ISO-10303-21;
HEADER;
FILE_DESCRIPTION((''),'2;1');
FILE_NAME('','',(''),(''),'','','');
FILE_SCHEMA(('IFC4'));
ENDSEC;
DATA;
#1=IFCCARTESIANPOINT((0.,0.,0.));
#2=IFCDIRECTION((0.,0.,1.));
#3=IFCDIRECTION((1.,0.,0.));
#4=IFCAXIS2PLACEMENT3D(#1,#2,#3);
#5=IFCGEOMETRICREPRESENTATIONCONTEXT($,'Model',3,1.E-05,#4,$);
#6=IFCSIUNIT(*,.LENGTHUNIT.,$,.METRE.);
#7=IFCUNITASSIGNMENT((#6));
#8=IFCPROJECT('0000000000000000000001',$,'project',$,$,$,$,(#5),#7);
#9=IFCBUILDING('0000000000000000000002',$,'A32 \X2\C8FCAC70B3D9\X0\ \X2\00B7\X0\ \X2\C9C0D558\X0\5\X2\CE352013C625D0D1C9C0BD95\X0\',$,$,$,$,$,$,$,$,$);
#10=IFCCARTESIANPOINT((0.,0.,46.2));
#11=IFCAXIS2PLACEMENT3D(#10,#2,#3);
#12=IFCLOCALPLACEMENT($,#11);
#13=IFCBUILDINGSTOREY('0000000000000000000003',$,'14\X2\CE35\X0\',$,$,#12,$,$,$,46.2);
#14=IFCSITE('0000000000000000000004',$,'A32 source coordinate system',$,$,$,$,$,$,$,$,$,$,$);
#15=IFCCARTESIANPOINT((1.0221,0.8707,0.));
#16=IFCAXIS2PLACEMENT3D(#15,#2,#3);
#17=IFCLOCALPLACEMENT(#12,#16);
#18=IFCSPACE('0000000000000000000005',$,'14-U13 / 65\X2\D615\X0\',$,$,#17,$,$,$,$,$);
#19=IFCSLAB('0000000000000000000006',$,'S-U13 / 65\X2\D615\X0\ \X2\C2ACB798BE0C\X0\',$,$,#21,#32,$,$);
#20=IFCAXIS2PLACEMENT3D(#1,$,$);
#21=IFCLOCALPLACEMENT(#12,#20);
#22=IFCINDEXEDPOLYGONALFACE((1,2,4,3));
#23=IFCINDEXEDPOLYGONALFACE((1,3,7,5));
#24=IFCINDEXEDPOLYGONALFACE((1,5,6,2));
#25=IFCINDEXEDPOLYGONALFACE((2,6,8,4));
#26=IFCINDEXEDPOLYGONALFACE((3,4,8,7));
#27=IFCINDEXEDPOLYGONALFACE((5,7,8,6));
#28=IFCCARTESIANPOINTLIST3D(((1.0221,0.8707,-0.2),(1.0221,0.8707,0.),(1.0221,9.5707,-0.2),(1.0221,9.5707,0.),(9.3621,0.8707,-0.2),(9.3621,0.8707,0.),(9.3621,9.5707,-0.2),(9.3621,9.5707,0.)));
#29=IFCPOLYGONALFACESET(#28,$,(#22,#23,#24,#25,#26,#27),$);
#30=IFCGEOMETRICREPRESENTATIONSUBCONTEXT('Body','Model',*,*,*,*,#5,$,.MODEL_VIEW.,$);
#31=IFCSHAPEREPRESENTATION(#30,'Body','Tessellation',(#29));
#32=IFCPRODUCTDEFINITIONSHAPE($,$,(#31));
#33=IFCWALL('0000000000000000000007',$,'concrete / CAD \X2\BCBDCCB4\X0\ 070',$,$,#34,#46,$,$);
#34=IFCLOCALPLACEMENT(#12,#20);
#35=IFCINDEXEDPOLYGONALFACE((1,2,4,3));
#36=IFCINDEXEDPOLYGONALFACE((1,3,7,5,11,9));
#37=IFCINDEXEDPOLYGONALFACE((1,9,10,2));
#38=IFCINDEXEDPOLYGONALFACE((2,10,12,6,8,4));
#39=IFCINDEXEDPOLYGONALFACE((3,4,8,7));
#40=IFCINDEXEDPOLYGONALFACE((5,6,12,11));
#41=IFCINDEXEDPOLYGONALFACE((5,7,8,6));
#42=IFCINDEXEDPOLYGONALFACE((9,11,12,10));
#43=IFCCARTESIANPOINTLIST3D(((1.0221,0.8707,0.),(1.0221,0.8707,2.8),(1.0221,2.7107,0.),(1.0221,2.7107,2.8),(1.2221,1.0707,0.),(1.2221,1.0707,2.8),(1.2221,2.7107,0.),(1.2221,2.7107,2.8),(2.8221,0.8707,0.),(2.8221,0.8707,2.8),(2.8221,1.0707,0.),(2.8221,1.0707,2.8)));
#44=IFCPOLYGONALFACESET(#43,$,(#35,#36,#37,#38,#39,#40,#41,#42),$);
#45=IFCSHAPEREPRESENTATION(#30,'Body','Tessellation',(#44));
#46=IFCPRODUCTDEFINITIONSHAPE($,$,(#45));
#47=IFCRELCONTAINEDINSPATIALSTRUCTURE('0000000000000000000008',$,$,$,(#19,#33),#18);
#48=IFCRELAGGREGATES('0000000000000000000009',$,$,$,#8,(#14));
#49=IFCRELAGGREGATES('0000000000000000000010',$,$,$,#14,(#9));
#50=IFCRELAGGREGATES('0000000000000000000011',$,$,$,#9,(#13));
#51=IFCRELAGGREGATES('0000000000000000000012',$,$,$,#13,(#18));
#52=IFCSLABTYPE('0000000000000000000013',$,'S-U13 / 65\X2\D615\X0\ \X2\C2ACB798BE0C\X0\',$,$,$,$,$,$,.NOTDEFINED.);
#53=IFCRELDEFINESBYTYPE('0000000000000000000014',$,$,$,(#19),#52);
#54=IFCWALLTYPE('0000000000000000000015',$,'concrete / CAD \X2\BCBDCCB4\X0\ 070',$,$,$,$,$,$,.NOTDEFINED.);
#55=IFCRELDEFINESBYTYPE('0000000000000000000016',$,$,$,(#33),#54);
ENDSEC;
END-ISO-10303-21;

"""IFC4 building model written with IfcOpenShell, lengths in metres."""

from ifc_helpers import new_model, si_unit, frame, origin, origin_with_axes, place, context, subcontext, project, spatial, polyline, outline, extrude, source, transform, mapped, type_object, type_shapes, element, save


model = new_model("IFC4")

# Units and contexts
model_context = context("Model", 3, precision=1e-05, world=origin_with_axes())
body_context = subcontext(model_context, "Body", "Model", "MODEL_VIEW")
ifc_project = project(units=[si_unit("LENGTHUNIT", "METRE")], contexts=[model_context])

# Site, building, storey, space
storey_placement = place(None, frame((0.0, 0.0, 46.2), z_axis=(0.0, 0.0, 1.0), x_axis=(1.0, 0.0, 0.0)))
space_placement = place(storey_placement, frame((1.0221, 0.8707, 0.0), z_axis=(0.0, 0.0, 1.0), x_axis=(1.0, 0.0, 0.0)))
site = spatial("IfcSite", under=ifc_project, Name="A32 source coordinate system")
building = spatial("IfcBuilding", under=site, Name="A32 주거동 · 지하5층–옥탑지붕")
storey = spatial("IfcBuildingStorey", under=building, at=storey_placement, Name="14층", Elevation=46.2)
space = spatial("IfcSpace", under=storey, at=space_placement, Name="14-U13 / 65형")

# Slab
slab_type = type_object("IfcSlabType", Name="S-U13 / 65형 슬래브", PredefinedType="NOTDEFINED")
shared_shape_1 = source(origin(), body_context, "Body", "SweptSolid", [
    extrude(outline(polyline([(0.0, 0.0), (0.0, 8.7), (8.34, 8.7), (8.34, 0.0), (0.0, 0.0)])), frame((0.0, 0.0, -0.2)), (0.0, 0.0, 1.0), 0.2),
])
type_shapes(slab_type, [shared_shape_1])
slab_placement = place(space_placement, origin_with_axes())
element("IfcSlab", 1, at=slab_placement, inside=space, type_object=slab_type, Name="S-U13 / 65형 슬래브", context=body_context, shape_type="MappedRepresentation", body=[
    mapped(shared_shape_1, transform((0.0, 0.0, 0.0), scale=1.0)),
])

# Wall
wall_type_1 = type_object("IfcWallType", Name="concrete / CAD 벽체 070", PredefinedType="NOTDEFINED")
shared_shape_2 = source(origin(), body_context, "Body", "SweptSolid", [
    extrude(outline(polyline([(0.2, 1.84), (0.2, 0.2), (1.8, 0.2), (1.8, 0.0), (0.0, 0.0), (0.0, 1.84), (0.2, 1.84)])), origin(), (0.0, 0.0, 1.0), 2.8),
])
type_shapes(wall_type_1, [shared_shape_2])
wall_1_placement = place(space_placement, origin_with_axes())
element("IfcWall", 2, at=wall_1_placement, inside=space, type_object=wall_type_1, Name="concrete / CAD 벽체 070", context=body_context, shape_type="MappedRepresentation", body=[
    mapped(shared_shape_2, transform((0.0, 0.0, 0.0), scale=1.0)),
])

save(model, "model.ifc")
